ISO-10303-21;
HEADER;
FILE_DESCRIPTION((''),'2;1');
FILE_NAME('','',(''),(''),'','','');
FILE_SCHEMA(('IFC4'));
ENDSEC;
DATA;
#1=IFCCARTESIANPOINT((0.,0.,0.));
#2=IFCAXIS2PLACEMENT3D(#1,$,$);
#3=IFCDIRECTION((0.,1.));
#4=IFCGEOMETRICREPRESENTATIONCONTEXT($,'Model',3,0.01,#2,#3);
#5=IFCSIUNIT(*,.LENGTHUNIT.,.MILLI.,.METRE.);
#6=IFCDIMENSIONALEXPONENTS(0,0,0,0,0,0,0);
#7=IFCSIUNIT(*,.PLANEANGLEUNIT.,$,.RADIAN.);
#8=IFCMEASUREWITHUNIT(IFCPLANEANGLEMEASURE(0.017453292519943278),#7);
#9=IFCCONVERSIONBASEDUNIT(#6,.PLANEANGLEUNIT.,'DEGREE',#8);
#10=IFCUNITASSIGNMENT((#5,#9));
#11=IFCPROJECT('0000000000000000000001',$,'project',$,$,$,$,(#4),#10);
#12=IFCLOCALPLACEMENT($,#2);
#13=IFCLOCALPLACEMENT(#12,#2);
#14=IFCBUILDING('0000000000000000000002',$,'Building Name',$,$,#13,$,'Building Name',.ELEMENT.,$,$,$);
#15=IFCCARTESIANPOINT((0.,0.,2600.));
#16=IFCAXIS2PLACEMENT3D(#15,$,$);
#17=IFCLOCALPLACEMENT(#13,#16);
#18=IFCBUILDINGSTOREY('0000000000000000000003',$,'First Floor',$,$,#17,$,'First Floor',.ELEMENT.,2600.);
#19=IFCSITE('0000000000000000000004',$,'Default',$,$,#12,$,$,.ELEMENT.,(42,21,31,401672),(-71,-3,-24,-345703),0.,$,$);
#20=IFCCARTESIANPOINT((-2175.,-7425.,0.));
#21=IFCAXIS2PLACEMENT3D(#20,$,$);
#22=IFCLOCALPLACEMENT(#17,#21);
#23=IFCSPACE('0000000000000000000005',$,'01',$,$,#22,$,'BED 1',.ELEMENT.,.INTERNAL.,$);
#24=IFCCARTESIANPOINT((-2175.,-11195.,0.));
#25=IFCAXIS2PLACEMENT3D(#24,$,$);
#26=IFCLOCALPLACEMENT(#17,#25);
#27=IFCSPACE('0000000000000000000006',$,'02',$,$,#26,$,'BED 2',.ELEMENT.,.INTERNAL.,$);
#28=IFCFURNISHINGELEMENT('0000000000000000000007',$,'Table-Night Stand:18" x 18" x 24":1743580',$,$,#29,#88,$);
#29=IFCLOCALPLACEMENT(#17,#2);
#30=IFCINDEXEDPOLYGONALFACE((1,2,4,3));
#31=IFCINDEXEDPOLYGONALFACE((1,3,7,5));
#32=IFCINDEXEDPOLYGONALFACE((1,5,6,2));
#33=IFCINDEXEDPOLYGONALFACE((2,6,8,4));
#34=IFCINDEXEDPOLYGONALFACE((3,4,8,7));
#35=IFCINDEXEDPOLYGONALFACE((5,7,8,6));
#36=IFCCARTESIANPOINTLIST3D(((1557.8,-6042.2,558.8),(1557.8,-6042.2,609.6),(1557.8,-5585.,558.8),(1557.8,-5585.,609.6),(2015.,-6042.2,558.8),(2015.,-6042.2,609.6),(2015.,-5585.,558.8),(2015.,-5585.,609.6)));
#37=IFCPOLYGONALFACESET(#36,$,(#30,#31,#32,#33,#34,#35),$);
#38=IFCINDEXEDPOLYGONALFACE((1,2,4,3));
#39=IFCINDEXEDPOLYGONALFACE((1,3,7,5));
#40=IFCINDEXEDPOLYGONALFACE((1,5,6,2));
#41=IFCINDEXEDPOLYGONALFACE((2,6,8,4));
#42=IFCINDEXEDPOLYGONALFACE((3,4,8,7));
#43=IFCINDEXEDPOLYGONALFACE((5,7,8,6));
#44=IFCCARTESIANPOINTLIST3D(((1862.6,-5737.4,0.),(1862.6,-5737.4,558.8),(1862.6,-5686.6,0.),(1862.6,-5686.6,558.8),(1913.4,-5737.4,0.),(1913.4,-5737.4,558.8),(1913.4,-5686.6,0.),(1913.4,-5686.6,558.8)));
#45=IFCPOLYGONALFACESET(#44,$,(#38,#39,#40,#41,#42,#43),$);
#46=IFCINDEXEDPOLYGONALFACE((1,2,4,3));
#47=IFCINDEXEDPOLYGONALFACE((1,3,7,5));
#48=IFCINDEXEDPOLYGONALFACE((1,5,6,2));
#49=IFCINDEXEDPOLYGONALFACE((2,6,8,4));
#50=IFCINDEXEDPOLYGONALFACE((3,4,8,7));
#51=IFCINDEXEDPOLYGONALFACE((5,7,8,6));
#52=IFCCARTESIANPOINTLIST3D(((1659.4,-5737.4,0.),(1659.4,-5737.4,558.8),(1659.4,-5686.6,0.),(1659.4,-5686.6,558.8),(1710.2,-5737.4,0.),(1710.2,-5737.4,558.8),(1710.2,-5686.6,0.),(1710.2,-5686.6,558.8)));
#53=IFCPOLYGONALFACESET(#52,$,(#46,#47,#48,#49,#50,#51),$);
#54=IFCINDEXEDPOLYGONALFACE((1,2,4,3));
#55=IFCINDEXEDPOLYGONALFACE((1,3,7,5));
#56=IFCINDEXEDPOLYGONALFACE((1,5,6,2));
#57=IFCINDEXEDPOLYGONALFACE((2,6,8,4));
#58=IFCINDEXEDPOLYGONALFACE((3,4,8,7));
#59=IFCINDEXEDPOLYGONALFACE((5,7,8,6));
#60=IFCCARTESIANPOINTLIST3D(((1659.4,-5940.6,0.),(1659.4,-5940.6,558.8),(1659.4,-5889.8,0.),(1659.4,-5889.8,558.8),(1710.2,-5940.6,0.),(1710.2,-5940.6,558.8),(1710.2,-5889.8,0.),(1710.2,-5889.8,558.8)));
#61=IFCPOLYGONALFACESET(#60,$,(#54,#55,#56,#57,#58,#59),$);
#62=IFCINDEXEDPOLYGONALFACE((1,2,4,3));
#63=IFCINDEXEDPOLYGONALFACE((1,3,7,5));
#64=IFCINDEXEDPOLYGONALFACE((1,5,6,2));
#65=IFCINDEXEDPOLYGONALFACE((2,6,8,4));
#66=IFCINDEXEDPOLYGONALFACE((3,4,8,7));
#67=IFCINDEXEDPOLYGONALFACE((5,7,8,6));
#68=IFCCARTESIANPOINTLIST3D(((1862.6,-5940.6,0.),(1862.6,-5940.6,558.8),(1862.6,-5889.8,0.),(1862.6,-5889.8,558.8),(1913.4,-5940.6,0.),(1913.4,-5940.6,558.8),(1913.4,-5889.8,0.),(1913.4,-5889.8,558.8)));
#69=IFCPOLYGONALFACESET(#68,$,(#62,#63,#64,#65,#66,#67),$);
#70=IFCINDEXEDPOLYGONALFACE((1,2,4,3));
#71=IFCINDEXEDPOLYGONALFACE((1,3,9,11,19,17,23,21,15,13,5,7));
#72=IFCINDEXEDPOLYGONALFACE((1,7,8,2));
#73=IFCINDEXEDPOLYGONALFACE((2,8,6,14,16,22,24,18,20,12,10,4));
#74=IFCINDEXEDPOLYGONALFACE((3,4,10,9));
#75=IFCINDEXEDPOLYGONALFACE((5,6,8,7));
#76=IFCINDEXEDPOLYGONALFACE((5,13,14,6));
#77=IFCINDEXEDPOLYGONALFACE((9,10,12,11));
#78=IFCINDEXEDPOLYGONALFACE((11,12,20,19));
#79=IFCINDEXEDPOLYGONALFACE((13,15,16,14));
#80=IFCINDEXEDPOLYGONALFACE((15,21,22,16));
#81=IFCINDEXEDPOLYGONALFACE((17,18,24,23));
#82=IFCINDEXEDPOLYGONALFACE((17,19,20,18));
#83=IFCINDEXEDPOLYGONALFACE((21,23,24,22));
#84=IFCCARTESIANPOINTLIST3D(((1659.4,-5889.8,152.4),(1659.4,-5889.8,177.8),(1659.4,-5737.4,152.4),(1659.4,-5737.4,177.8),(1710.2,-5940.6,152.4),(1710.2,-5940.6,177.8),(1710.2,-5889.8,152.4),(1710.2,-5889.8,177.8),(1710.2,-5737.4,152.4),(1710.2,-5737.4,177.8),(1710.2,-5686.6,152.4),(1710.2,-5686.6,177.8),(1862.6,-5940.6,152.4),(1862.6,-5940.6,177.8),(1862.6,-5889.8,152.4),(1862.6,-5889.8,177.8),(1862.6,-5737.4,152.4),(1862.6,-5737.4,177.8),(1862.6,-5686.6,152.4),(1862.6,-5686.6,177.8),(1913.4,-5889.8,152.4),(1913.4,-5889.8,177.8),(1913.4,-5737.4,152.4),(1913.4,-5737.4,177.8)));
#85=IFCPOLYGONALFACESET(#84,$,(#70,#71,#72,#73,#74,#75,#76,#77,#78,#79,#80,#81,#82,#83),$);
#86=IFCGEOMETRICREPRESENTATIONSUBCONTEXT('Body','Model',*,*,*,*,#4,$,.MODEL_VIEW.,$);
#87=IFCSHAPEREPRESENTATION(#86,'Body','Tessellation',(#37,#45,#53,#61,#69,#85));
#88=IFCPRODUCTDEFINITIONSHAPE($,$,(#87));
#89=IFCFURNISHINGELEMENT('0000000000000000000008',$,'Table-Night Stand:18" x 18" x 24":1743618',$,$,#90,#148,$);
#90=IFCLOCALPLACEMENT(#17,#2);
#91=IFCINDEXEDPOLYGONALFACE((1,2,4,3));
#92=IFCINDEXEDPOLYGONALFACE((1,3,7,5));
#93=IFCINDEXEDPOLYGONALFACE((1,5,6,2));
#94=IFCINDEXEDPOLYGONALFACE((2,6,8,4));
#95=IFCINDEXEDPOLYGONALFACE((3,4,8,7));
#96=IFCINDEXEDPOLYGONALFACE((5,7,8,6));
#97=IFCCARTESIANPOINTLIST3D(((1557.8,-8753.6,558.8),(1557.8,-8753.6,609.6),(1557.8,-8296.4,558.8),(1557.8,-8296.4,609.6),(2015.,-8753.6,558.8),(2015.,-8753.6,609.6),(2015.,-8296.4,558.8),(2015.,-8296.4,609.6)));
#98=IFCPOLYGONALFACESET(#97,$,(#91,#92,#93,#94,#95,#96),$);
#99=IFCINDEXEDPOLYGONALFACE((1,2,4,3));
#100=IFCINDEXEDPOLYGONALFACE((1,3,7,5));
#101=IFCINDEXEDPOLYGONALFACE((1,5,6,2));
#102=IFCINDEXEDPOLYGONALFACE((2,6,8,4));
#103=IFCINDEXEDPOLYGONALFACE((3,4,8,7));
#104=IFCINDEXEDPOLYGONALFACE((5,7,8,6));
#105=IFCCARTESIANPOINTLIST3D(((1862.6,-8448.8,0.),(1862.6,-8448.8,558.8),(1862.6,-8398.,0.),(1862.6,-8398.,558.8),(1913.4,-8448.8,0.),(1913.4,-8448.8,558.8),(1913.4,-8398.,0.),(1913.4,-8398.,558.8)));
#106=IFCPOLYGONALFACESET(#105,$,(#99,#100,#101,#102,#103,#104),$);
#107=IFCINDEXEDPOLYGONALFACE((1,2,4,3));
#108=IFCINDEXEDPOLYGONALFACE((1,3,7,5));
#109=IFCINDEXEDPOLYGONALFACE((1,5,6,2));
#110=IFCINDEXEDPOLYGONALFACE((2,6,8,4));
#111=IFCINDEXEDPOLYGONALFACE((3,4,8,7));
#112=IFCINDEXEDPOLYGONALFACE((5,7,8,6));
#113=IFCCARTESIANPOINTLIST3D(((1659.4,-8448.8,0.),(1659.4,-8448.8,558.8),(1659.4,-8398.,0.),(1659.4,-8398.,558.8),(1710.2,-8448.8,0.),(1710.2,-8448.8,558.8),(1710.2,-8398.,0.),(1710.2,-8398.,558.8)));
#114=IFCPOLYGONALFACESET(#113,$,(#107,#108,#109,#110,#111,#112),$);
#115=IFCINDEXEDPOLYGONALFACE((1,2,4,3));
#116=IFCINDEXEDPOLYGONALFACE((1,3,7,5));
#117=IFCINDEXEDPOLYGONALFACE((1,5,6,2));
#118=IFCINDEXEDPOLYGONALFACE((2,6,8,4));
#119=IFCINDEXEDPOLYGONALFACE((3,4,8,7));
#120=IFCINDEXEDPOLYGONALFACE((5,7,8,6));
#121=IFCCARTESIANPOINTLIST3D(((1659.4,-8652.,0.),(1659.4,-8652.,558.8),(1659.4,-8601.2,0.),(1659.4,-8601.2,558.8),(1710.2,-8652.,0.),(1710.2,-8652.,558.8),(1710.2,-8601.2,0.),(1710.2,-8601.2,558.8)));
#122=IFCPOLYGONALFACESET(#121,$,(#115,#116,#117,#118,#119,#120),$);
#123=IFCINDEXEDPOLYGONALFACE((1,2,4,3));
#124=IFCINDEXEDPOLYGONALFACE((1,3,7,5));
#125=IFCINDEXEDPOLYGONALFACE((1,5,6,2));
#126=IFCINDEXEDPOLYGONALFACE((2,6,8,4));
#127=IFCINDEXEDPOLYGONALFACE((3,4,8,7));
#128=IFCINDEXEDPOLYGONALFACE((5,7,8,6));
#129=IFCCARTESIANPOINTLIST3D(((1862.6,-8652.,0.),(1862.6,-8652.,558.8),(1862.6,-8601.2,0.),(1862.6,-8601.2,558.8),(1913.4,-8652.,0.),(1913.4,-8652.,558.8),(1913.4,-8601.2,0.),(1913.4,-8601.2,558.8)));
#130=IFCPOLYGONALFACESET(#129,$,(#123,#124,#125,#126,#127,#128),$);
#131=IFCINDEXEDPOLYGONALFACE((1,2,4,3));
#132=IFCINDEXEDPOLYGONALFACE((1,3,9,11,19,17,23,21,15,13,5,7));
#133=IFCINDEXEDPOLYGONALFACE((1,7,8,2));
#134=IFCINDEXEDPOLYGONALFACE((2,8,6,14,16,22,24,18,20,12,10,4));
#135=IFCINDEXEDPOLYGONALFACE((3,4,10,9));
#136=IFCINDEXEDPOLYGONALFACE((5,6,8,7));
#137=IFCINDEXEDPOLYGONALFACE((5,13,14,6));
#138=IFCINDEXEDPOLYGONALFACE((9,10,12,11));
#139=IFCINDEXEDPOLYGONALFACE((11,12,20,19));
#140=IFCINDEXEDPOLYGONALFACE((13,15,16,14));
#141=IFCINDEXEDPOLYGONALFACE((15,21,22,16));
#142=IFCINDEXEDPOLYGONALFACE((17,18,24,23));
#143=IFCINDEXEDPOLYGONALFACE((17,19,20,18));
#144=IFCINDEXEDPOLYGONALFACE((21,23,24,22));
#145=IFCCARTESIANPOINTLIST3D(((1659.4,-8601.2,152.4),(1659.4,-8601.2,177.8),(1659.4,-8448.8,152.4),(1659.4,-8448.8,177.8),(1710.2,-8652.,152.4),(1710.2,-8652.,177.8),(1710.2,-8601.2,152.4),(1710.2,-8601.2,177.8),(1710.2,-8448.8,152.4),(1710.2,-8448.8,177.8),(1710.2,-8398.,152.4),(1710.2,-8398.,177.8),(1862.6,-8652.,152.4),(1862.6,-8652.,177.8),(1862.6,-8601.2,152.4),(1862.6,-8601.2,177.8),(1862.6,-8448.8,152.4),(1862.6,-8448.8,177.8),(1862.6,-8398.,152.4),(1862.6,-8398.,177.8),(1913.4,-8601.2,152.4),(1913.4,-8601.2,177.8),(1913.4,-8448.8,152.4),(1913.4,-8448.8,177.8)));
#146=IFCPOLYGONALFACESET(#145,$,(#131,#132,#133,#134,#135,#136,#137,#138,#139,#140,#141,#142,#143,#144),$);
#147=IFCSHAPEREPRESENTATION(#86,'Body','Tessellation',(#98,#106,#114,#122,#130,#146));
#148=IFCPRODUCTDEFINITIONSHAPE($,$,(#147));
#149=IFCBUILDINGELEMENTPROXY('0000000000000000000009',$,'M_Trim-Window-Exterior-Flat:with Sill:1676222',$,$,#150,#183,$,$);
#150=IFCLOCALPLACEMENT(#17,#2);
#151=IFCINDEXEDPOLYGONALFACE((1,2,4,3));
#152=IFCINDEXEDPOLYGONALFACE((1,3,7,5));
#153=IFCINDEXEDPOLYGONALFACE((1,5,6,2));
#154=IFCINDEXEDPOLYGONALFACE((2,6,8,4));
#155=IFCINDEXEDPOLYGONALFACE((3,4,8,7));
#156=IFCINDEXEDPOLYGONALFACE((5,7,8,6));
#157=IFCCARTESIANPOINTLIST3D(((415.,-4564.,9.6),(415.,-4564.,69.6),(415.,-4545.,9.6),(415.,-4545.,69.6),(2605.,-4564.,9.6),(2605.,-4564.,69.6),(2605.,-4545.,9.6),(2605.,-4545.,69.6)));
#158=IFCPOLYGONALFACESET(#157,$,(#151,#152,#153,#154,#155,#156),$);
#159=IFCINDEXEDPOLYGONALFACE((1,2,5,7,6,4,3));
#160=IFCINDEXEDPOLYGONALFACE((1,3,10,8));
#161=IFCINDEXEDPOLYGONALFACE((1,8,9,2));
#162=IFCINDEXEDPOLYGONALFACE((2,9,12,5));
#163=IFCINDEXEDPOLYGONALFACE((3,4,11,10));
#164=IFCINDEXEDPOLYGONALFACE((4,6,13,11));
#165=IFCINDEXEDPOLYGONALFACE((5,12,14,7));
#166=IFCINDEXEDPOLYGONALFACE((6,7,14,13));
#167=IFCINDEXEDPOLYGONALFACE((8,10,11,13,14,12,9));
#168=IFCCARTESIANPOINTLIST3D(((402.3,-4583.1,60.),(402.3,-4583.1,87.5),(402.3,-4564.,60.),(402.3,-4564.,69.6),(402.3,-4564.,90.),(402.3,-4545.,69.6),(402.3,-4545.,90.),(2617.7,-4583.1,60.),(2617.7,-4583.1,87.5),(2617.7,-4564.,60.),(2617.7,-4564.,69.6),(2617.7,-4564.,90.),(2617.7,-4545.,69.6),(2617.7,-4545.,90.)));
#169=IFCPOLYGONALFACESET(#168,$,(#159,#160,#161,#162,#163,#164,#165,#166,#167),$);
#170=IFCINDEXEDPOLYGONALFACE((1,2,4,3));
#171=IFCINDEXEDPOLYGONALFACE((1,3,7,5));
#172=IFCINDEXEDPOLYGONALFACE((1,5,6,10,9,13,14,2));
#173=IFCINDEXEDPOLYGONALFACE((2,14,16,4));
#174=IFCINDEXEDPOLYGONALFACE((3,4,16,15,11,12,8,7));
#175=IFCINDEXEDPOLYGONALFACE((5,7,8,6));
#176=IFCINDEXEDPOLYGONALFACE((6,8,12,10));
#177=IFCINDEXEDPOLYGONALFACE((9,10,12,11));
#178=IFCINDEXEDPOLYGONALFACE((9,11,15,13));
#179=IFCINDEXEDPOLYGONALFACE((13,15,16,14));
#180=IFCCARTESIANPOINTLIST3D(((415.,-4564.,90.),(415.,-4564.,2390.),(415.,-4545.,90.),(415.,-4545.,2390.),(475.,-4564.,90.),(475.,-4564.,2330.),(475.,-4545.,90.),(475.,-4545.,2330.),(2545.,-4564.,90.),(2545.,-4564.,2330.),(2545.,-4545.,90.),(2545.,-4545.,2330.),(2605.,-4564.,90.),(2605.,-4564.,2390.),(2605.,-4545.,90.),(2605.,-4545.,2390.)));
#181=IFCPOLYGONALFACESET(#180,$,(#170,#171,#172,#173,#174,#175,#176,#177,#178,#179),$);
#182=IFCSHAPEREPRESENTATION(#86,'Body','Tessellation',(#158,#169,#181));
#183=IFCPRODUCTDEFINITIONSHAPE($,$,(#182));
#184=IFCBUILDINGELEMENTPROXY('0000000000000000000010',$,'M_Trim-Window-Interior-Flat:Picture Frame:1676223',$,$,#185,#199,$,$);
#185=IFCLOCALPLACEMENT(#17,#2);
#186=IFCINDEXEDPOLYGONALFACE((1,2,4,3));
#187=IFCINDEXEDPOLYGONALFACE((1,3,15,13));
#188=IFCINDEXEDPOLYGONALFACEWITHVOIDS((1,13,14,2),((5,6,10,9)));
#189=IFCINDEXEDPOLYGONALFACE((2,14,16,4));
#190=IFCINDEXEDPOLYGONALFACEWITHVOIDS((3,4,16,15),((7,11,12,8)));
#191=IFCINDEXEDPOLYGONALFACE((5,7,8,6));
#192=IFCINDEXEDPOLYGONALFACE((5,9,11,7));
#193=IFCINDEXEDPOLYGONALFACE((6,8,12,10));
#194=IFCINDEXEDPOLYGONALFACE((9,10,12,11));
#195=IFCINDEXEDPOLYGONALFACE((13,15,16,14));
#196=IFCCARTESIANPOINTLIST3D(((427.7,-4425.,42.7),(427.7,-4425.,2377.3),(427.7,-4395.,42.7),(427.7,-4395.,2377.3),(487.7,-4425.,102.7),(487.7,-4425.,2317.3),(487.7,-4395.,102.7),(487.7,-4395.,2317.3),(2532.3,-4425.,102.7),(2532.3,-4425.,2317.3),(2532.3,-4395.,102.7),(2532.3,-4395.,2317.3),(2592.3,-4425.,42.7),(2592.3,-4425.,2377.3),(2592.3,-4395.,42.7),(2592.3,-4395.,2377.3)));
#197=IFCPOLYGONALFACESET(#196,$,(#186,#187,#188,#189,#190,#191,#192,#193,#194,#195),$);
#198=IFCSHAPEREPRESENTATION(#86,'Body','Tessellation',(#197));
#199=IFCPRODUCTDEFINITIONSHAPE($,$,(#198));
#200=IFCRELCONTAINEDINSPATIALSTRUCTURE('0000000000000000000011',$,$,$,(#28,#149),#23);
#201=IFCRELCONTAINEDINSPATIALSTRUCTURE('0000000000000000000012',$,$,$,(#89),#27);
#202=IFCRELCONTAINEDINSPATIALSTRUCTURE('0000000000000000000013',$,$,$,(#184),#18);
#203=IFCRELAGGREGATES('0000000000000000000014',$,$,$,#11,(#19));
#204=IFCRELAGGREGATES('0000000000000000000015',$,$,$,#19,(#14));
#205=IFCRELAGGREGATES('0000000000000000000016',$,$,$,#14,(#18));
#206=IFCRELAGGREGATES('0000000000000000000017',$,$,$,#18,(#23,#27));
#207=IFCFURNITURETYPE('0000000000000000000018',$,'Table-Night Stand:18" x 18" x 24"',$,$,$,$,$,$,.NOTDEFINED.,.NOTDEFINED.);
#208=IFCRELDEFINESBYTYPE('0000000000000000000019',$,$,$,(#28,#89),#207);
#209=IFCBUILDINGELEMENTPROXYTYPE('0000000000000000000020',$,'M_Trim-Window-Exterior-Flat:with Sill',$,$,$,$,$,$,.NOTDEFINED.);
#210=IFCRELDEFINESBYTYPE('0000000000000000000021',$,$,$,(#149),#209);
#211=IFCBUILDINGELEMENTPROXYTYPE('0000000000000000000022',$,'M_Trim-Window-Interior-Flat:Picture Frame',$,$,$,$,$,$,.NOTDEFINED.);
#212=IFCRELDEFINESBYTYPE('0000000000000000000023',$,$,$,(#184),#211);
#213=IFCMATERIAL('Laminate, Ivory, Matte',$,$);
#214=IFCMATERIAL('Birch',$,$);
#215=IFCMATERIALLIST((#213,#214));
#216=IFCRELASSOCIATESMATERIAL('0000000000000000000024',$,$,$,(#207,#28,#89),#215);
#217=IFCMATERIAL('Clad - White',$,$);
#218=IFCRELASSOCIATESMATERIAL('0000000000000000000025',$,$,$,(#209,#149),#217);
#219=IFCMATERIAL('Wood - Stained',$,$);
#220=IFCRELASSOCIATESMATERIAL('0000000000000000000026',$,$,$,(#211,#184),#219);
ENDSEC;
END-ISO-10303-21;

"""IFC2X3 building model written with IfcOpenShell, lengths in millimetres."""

from ifc_helpers import new_model, entity, si_unit, converted_unit, direction, frame, frame_2d, origin, origin_2d_with_axis, place, context, subcontext, project, spatial, polyline, rectangle, outline, extrude, source, transform, mapped, material, material_list, type_object, type_shapes, element, save


model = new_model("IFC2X3")

# Units and contexts
model_context = context("Model", 3, precision=0.01, world=origin(), true_north=direction((0.0, 1.0)))
body_context = subcontext(model_context, "Body", "Model", "MODEL_VIEW")
ifc_project = project(units=[si_unit("LENGTHUNIT", "METRE", prefix="MILLI"), converted_unit("PLANEANGLEUNIT", "DEGREE", entity("IfcPlaneAngleMeasure", 0.017453292519943278), si_unit("PLANEANGLEUNIT", "RADIAN"), dimensions=[0, 0, 0, 0, 0, 0, 0])], contexts=[model_context])

# Site, building, storey
site_placement = place(None, origin())
site = spatial("IfcSite", under=ifc_project, at=site_placement, Name="Default", CompositionType="ELEMENT", RefLatitude=(42, 21, 31, 401672), RefLongitude=(-71, -3, -24, -345703), RefElevation=0.0)
building_placement = place(site_placement, origin())
building = spatial("IfcBuilding", under=site, at=building_placement, Name="Building Name", LongName="Building Name", CompositionType="ELEMENT")
storey_placement = place(building_placement, frame((0.0, 0.0, 2600.0)))
storey = spatial("IfcBuildingStorey", under=building, at=storey_placement, Name="First Floor", LongName="First Floor", CompositionType="ELEMENT", Elevation=2600.0)

# Shared definitions
space_1_placement = place(storey_placement, frame((-2175.0, -7425.0, 0.0)))
space_1 = spatial("IfcSpace", under=storey, at=space_1_placement, Name="01", LongName="BED 1", CompositionType="ELEMENT", InteriorOrExteriorSpace="INTERNAL")

# Furnishing element
ifc_material_1 = material(Name="Laminate, Ivory, Matte")
ifc_material_2 = material(Name="Birch")
ifc_material_list_1 = material_list([ifc_material_1, ifc_material_2])
furniture_type_1 = type_object("IfcFurnitureType", Name="Table-Night Stand:18\" x 18\" x 24\"", AssemblyPlace="NOTDEFINED", material=ifc_material_list_1)
shared_shape_1 = source(origin(), body_context, "Body", "SweptSolid", [
    extrude(rectangle(XDim=457.2, YDim=457.2, at=origin_2d_with_axis()), frame((232.3, 228.6, 558.8), z_axis=(0.0, 0.0, 1.0), x_axis=(0.0, 1.0, 0.0)), (0.0, 0.0, 1.0), 50.8),
    extrude(rectangle(XDim=50.8, YDim=50.8, at=origin_2d_with_axis()), frame((333.9, 330.2, 0.0), z_axis=(0.0, 0.0, 1.0), x_axis=(-1.0, 0.0, 0.0)), (0.0, 0.0, 1.0), 558.8),
    extrude(rectangle(XDim=50.8, YDim=50.8, at=frame_2d((0.0, 0.0), x_axis=(1.0, 0.0))), frame((130.7, 330.2, 0.0), z_axis=(0.0, 0.0, 1.0), x_axis=(-1.0, 0.0, 0.0)), (0.0, 0.0, 1.0), 558.8),
    extrude(rectangle(XDim=50.8, YDim=50.8, at=frame_2d((0.0, 0.0), x_axis=(1.0, 0.0))), frame((130.7, 127.0, 0.0), z_axis=(0.0, 0.0, 1.0), x_axis=(-1.0, 0.0, 0.0)), (0.0, 0.0, 1.0), 558.8),
    extrude(rectangle(XDim=50.8, YDim=50.8, at=frame_2d((0.0, 0.0), x_axis=(1.0, 0.0))), frame((333.9, 127.0, 0.0), z_axis=(0.0, 0.0, 1.0), x_axis=(-1.0, 0.0, 0.0)), (0.0, 0.0, 1.0), 558.8),
    extrude(outline(polyline([(-127.0, 76.2), (-127.0, -76.2), (-76.2, -76.2), (-76.2, -127.0), (76.2, -127.0), (76.2, -76.2), (127.0, -76.2), (127.0, 76.2), (76.2, 76.2), (76.2, 127.0), (-76.2, 127.0), (-76.2, 76.2), (-127.0, 76.2)])), frame((232.3, 228.6, 152.4), z_axis=(0.0, 0.0, -1.0), x_axis=(0.0, -1.0, 0.0)), (0.0, 0.0, -1.0), 25.4),
])
type_shapes(furniture_type_1, [shared_shape_1])
furnishing_1_placement = place(space_1_placement, frame((3729.1, 1382.8, 0.0)))
element("IfcFurnishingElement", 1, at=furnishing_1_placement, inside=space_1, type_object=furniture_type_1, material=ifc_material_list_1, Name="Table-Night Stand:18\" x 18\" x 24\":1743580", context=body_context, shape_type="MappedRepresentation", body=[
    mapped(shared_shape_1, transform((0.0, 0.0, 0.0), scale=1.0)),
])

# Shared definitions
space_2_placement = place(storey_placement, frame((-2175.0, -11195.0, 0.0)))
space_2 = spatial("IfcSpace", under=storey, at=space_2_placement, Name="02", LongName="BED 2", CompositionType="ELEMENT", InteriorOrExteriorSpace="INTERNAL")

# Furnishing element
furnishing_2_placement = place(space_2_placement, frame((3729.1, 2441.4, 0.0)))
element("IfcFurnishingElement", 2, at=furnishing_2_placement, inside=space_2, type_object=furniture_type_1, material=ifc_material_list_1, Name="Table-Night Stand:18\" x 18\" x 24\":1743618", context=body_context, shape_type="MappedRepresentation", body=[
    mapped(shared_shape_1, transform((0.0, 0.0, 0.0), scale=1.0)),
])

# Building element proxies
ifc_material_3 = material(Name="Clad - White")
building_element_proxy_type_1 = type_object("IfcBuildingElementProxyType", Name="M_Trim-Window-Exterior-Flat:with Sill", PredefinedType="NOTDEFINED", material=ifc_material_3)
shared_shape_2 = source(origin(), body_context, "Body", "SweptSolid", [
    extrude(rectangle(XDim=2190.0, YDim=60.0, at=frame_2d((0.0, 0.0), x_axis=(1.0, 0.0))), frame((0.0, -2290.4, 0.0), z_axis=(0.0, 0.0, 1.0), x_axis=(-1.0, 0.0, 0.0)), (0.0, 0.0, 1.0), 19.0),
    extrude(outline(polyline([(-19.0, -15.2), (0.0, -15.2), (0.0, -5.7), (19.0, -5.7), (19.0, 14.8), (0.0, 14.8), (-19.0, 12.3), (-19.0, -15.2)])), frame((-1107.7, -2254.8, 19.0), z_axis=(1.0, 0.0, 0.0), x_axis=(0.0, 0.0, -1.0)), (0.0, 0.0, 1.0), 2215.4),
    extrude(outline(polyline([(-1165.0, -1095.0), (1135.0, -1095.0), (1135.0, -1035.0), (-1105.0, -1035.0), (-1105.0, 1035.0), (1135.0, 1035.0), (1135.0, 1095.0), (-1165.0, 1095.0), (-1165.0, -1095.0)])), frame((0.0, -1105.0, 0.0), z_axis=(0.0, 0.0, 1.0), x_axis=(0.0, -1.0, 0.0)), (0.0, 0.0, 1.0), 19.0),
])
type_shapes(building_element_proxy_type_1, [shared_shape_2])
proxy_1_placement = place(space_1_placement, frame((3685.0, 2880.0, 2330.0), z_axis=(0.0, -1.0, 0.0), x_axis=(1.0, 0.0, 0.0)))
element("IfcBuildingElementProxy", 3, at=proxy_1_placement, inside=space_1, type_object=building_element_proxy_type_1, material=ifc_material_3, Name="M_Trim-Window-Exterior-Flat:with Sill:1676222", context=body_context, shape_type="MappedRepresentation", body=[
    mapped(shared_shape_2, transform((0.0, 0.0, 0.0), scale=1.0)),
])
ifc_material_4 = material(Name="Wood - Stained")
building_element_proxy_type_2 = type_object("IfcBuildingElementProxyType", Name="M_Trim-Window-Interior-Flat:Picture Frame", PredefinedType="NOTDEFINED", material=ifc_material_4)
shared_shape_3 = source(origin(), body_context, "Body", "SweptSolid", [
    extrude(outline(polyline([(-1082.3, -1167.3), (1082.3, -1167.3), (1082.3, 1167.3), (-1082.3, 1167.3), (-1082.3, -1167.3)]), holes=[polyline([(-1022.3, -1107.3), (-1022.3, 1107.3), (1022.3, 1107.3), (1022.3, -1107.3), (-1022.3, -1107.3)])]), frame((0.0, -1120.0, 0.0), z_axis=(0.0, 0.0, 1.0), x_axis=(-1.0, 0.0, 0.0)), (0.0, 0.0, 1.0), 30.0),
])
type_shapes(building_element_proxy_type_2, [shared_shape_3])
proxy_2_placement = place(storey_placement, frame((1510.0, -4425.0, 2330.0), z_axis=(0.0, 1.0, 0.0), x_axis=(-1.0, 0.0, 0.0)))
element("IfcBuildingElementProxy", 4, at=proxy_2_placement, inside=storey, type_object=building_element_proxy_type_2, material=ifc_material_4, Name="M_Trim-Window-Interior-Flat:Picture Frame:1676223", context=body_context, shape_type="MappedRepresentation", body=[
    mapped(shared_shape_3, transform((0.0, 0.0, 0.0), scale=1.0)),
])

save(model, "model.ifc")
